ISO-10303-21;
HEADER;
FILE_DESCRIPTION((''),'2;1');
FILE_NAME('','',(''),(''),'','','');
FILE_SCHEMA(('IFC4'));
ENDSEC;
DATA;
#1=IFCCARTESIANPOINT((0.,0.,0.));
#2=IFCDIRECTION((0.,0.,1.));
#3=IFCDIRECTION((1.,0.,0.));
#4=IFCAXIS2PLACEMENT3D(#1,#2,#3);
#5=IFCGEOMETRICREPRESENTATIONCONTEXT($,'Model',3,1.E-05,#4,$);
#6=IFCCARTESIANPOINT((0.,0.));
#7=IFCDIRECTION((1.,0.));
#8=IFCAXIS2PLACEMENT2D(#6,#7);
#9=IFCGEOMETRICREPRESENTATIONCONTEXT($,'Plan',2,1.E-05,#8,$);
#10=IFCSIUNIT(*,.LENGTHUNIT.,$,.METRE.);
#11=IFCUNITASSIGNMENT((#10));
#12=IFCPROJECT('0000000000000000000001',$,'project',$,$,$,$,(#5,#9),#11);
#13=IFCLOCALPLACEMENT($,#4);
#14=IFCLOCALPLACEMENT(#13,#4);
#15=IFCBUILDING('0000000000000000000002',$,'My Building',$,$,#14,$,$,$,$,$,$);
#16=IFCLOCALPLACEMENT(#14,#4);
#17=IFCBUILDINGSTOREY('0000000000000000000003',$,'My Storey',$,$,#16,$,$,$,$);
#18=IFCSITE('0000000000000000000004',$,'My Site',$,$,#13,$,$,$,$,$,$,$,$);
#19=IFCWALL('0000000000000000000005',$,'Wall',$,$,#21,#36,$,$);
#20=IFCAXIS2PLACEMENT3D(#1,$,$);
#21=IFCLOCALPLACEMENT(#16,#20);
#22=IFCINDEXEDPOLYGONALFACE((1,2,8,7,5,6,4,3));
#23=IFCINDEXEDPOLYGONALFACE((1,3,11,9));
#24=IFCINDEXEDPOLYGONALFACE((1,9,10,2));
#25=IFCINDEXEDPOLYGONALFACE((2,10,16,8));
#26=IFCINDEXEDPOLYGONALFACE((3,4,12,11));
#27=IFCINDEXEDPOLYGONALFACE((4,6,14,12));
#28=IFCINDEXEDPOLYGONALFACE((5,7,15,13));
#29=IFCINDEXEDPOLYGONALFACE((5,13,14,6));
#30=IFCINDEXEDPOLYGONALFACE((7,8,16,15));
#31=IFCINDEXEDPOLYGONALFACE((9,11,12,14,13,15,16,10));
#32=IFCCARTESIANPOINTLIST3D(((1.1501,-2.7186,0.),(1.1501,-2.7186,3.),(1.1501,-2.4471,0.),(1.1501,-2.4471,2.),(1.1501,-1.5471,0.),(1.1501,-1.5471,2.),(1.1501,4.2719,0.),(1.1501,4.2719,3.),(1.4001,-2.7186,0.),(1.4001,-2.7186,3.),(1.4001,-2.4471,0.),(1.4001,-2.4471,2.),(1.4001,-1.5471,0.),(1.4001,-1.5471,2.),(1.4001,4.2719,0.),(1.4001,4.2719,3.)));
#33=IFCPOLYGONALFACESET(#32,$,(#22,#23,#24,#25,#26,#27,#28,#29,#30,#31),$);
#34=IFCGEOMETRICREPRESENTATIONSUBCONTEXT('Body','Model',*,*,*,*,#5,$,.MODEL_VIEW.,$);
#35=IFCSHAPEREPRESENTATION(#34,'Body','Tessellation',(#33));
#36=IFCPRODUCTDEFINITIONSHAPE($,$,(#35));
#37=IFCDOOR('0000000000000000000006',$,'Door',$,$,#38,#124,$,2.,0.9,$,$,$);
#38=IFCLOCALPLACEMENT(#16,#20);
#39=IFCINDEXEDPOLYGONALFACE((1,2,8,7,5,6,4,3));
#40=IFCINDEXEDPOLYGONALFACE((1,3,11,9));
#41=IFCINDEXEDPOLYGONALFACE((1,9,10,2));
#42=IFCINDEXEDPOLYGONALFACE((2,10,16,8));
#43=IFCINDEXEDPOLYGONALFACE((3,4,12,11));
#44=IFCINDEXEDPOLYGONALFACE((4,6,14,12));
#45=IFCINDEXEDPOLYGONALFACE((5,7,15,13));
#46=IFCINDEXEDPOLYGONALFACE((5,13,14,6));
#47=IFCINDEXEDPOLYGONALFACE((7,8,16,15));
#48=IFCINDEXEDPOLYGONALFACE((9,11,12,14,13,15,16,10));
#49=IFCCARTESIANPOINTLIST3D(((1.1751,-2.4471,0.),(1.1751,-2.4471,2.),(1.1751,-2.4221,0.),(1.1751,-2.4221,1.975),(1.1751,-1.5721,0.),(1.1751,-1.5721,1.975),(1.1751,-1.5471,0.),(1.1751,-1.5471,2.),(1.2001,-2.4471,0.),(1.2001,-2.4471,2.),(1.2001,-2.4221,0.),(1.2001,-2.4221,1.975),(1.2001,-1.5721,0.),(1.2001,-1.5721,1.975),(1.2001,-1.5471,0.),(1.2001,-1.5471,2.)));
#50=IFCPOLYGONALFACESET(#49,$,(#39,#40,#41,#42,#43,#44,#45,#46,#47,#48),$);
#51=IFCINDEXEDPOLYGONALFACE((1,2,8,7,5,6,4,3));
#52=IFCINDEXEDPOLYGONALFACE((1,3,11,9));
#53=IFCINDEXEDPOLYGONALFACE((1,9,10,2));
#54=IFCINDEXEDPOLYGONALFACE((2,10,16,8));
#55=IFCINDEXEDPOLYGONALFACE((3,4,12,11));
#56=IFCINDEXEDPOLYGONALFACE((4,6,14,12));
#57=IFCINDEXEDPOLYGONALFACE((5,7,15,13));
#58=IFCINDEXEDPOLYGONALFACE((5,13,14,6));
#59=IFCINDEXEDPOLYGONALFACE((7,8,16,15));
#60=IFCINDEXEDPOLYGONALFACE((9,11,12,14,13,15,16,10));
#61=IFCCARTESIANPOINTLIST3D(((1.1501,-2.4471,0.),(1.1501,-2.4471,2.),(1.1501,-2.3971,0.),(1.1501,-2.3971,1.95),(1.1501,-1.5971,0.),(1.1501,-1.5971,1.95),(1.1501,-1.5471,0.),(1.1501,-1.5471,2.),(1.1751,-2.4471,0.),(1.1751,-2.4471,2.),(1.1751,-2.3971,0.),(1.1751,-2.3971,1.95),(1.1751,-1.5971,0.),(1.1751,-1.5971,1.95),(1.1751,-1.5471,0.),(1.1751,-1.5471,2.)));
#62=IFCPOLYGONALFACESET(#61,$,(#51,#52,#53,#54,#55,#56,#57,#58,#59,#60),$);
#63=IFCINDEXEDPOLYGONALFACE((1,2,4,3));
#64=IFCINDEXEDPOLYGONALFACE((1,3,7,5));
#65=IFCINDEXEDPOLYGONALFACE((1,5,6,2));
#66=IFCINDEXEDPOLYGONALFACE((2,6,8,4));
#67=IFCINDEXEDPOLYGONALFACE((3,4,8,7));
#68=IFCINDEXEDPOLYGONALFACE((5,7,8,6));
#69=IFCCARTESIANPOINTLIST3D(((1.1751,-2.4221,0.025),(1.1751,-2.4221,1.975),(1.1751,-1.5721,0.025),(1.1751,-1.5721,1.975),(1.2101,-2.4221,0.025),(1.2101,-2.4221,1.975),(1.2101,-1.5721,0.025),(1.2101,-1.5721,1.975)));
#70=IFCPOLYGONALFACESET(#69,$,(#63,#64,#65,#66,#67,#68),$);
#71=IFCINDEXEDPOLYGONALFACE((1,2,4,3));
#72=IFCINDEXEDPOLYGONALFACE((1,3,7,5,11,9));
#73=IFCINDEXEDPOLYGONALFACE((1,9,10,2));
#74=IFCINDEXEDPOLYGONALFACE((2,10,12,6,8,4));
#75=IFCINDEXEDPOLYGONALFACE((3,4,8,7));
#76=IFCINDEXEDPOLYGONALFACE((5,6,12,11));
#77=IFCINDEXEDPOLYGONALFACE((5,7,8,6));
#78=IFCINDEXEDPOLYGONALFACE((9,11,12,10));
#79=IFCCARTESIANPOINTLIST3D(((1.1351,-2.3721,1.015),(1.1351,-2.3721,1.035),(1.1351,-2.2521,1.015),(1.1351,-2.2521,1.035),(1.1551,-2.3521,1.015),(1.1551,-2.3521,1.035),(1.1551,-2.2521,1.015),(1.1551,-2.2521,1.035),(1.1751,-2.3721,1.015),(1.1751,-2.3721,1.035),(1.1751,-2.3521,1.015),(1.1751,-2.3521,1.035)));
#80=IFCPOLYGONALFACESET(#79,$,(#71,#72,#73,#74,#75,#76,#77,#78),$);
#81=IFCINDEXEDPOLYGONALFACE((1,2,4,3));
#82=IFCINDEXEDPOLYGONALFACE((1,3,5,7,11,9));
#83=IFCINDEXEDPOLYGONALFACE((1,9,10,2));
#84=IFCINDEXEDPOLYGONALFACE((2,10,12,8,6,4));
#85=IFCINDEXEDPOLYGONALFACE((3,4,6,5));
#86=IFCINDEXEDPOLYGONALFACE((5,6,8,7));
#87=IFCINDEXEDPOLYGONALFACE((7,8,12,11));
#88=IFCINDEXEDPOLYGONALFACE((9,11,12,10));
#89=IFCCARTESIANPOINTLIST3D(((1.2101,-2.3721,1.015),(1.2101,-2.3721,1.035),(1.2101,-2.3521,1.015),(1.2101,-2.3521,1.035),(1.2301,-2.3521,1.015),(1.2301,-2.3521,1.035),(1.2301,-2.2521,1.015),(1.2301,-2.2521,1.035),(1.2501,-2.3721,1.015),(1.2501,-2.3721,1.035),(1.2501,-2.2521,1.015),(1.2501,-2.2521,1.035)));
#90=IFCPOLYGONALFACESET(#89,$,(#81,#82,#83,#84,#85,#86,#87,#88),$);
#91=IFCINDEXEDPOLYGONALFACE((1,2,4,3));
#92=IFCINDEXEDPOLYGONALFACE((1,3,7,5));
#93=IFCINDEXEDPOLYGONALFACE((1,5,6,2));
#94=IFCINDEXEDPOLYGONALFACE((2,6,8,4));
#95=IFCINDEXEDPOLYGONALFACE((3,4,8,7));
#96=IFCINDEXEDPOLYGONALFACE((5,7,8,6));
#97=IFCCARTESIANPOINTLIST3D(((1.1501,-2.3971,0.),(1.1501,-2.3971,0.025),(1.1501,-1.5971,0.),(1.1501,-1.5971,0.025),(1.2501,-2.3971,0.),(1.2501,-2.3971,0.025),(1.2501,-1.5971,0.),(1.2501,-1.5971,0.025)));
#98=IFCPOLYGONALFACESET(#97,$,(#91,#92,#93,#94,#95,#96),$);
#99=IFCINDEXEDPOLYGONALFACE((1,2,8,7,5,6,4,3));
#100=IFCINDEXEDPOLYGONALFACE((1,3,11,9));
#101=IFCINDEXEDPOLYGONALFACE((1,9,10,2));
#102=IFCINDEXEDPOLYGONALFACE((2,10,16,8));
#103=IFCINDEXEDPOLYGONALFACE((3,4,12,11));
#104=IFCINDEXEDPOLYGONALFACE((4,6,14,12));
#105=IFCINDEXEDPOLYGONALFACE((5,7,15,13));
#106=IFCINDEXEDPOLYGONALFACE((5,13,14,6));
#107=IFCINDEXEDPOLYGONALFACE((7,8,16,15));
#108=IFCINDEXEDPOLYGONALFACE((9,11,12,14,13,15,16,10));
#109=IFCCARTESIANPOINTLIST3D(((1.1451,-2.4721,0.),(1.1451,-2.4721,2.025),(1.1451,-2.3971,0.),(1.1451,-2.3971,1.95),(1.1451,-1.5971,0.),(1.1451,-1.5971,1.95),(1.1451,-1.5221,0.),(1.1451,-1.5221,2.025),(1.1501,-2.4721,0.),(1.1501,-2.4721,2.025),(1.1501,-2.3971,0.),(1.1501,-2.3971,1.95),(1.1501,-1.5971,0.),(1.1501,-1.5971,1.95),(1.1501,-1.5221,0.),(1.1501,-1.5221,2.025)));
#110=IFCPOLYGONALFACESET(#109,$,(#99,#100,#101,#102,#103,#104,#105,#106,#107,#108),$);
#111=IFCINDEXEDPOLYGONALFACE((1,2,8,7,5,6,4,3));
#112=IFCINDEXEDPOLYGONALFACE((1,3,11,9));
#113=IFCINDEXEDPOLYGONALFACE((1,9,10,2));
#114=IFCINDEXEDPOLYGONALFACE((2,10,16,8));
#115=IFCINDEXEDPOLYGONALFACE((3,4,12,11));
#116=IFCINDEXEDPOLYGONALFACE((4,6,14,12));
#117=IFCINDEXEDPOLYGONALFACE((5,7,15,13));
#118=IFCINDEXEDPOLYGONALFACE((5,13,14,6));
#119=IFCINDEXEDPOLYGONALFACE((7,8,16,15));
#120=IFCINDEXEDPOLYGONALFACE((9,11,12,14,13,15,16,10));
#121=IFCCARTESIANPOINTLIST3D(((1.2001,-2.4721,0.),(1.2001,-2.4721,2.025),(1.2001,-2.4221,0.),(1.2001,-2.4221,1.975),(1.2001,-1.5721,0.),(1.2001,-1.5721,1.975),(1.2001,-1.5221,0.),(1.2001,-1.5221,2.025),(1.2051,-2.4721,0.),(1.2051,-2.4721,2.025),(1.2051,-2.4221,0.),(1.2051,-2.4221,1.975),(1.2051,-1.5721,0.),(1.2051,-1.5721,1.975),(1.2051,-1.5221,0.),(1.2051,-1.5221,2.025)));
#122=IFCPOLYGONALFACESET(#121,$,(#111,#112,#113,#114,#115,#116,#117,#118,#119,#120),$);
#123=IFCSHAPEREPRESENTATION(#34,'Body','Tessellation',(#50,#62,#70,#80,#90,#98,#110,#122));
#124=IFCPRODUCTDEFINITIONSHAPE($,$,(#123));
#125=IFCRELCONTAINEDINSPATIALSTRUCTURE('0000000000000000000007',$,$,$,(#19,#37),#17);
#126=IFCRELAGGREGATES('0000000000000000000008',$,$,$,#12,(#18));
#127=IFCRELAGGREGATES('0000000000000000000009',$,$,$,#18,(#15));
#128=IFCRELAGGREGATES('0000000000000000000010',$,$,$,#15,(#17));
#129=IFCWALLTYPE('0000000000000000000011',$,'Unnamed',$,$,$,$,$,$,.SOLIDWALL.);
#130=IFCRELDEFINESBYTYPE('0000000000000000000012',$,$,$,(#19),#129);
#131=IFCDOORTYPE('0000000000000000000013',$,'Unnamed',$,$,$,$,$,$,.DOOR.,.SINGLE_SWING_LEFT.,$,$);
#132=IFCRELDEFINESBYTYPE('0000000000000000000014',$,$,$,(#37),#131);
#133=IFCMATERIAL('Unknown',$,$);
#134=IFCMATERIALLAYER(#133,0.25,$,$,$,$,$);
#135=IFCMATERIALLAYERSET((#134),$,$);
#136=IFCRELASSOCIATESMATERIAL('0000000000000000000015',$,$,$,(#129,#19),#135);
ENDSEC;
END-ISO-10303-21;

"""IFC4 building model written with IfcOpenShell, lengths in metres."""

from ifc_helpers import new_model, entity, si_unit, frame, origin_with_axes, origin_2d_with_axis, place, context, subcontext, project, spatial, line, indexed_curve, outline, extrude, shape, source, transform, mapped, material, layer, layer_set, layer_usage, type_object, type_shapes, element, fill, save


model = new_model("IFC4")

# Units and contexts
model_context = context("Model", 3, precision=1e-05, world=origin_with_axes())
plan_context = context("Plan", 2, precision=1e-05, world=origin_2d_with_axis())
body_context_1 = subcontext(model_context, "Body", "Model", "MODEL_VIEW")
body_context_2 = subcontext(plan_context, "Body", "Plan", "PLAN_VIEW")
ifc_project = project(units=[si_unit("LENGTHUNIT", "METRE")], contexts=[model_context, plan_context])

# Site, building, storey
site_placement = place(None, origin_with_axes())
site = spatial("IfcSite", under=ifc_project, at=site_placement, Name="My Site")
building_placement = place(site_placement, origin_with_axes())
building = spatial("IfcBuilding", under=site, at=building_placement, Name="My Building")
storey_placement = place(building_placement, origin_with_axes())
storey = spatial("IfcBuildingStorey", under=building, at=storey_placement, Name="My Storey")

# Shared definitions
ifc_material = material(Name="Unknown")

# Shared definitions
ifc_layer_1 = layer(ifc_material, 0.25)
ifc_layer_set_1 = layer_set([ifc_layer_1])
wall_type_1 = type_object("IfcWallType", Name="Unnamed", PredefinedType="SOLIDWALL", material=ifc_layer_set_1)

# Wall, opening, door
ifc_layer_usage_1 = layer_usage(ifc_layer_set_1, "AXIS2", "POSITIVE", 0.0)
wall_1_placement = place(storey_placement, frame((1.1501, 4.2719, 0.0), z_axis=(0.0, 0.0, 1.0), x_axis=(0.0, -1.0, 0.0)))
wall_1 = element("IfcWall", 1, at=wall_1_placement, inside=storey, type_object=wall_type_1, material=ifc_layer_usage_1, Name="Wall", context=body_context_1, shape_type="SweptSolid", body=[
    extrude(outline(indexed_curve([(0.0, 0.0), (0.0, 0.25), (6.9904, 0.25), (6.9904, 0.0)], segments=[line(1, 2, 3, 4, 1)])), origin_with_axes(), (0.0, 0.0, 1.0), 3.0),
])
shared_shape_1 = source(origin_with_axes(), body_context_1, "Body", "SweptSolid", [
    extrude(outline(indexed_curve([(0.0, 0.0), (0.9, 0.0), (0.9, 2.0), (0.0, 2.0)], segments=[line(1, 2, 3, 4, 1)])), frame((0.0, -0.6, 0.0), z_axis=(0.0, -1.0, 0.0), x_axis=(1.0, 0.0, 0.0)), (0.0, 0.0, -1.0), 1.2),
])
opening_1_placement = place(wall_1_placement, frame((5.819, 0.0, 0.0), z_axis=(0.0, 0.0, 1.0), x_axis=(1.0, 0.0, 0.0)))
opening_1 = element("IfcOpeningElement", 2, at=opening_1_placement, cuts=wall_1, PredefinedType="OPENING", context=body_context_1, shape_type="MappedRepresentation", body=[
    mapped(shared_shape_1, transform((0.0, 0.0, 0.0), x_axis=(1.0, 0.0, 0.0), y_axis=(0.0, 1.0, 0.0), z_axis=(0.0, 0.0, 1.0), scale=1.0)),
])
door_type = type_object("IfcDoorType", Name="Unnamed", OperationType="SINGLE_SWING_LEFT", PredefinedType="DOOR")
shared_shape_2 = source(origin_with_axes(), body_context_1, "Body", "SweptSolid", [
    extrude(outline(indexed_curve([(0.0, 0.0), (0.0, 2.0), (0.9, 2.0), (0.9, 0.0), (0.875, 0.0), (0.875, 1.975), (0.025, 1.975), (0.025, 0.0)], segments=[line(1, 2, 3, 4, 5, 6, 7, 8, 1)])), frame((0.0, 0.025, 0.0), z_axis=(0.0, -1.0, 0.0), x_axis=(1.0, 0.0, 0.0)), (0.0, 0.0, -1.0), 0.025),
    extrude(outline(indexed_curve([(0.0, 0.0), (0.0, 2.0), (0.9, 2.0), (0.9, 0.0), (0.85, 0.0), (0.85, 1.95), (0.05, 1.95), (0.05, 0.0)], segments=[line(1, 2, 3, 4, 5, 6, 7, 8, 1)])), frame((0.0, 0.0, 0.0), z_axis=(0.0, -1.0, 0.0), x_axis=(1.0, 0.0, 0.0)), (0.0, 0.0, -1.0), 0.025),
    extrude(outline(indexed_curve([(0.0, 0.0), (0.85, 0.0), (0.85, 0.035), (0.0, 0.035)], segments=[line(1, 2, 3, 4, 1)])), frame((0.025, 0.025, 0.025), z_axis=(0.0, 0.0, 1.0), x_axis=(1.0, 0.0, 0.0)), (0.0, 0.0, 1.0), 1.95),
    extrude(outline(indexed_curve([(0.0, 0.0), (0.0, -0.04), (-0.12, -0.04), (-0.12, -0.02), (-0.02, -0.02), (-0.02, 0.0)], segments=[line(1, 2, 3, 4, 5, 6, 1)])), frame((0.825, 0.025, 1.015), z_axis=(0.0, 0.0, 1.0), x_axis=(1.0, 0.0, 0.0)), (0.0, 0.0, 1.0), 0.02),
    extrude(outline(indexed_curve([(0.0, 0.0), (0.0, 0.04), (-0.12, 0.04), (-0.12, 0.02), (-0.02, 0.02), (-0.02, 0.0)], segments=[line(1, 2, 3, 4, 5, 6, 1)])), frame((0.825, 0.06, 1.015), z_axis=(0.0, 0.0, 1.0), x_axis=(1.0, 0.0, 0.0)), (0.0, 0.0, 1.0), 0.02),
    extrude(outline(indexed_curve([(0.0, 0.0), (0.8, 0.0), (0.8, 0.1), (0.0, 0.1)], segments=[line(1, 2, 3, 4, 1)])), frame((0.05, 0.0, 0.0), z_axis=(0.0, 0.0, 1.0), x_axis=(1.0, 0.0, 0.0)), (0.0, 0.0, 1.0), 0.025),
    extrude(outline(indexed_curve([(0.0, 0.0), (0.0, 2.025), (0.95, 2.025), (0.95, 0.0), (0.875, 0.0), (0.875, 1.95), (0.075, 1.95), (0.075, 0.0)], segments=[line(1, 2, 3, 4, 5, 6, 7, 8, 1)])), frame((-0.025, -0.005, 0.0), z_axis=(0.0, -1.0, 0.0), x_axis=(1.0, 0.0, 0.0)), (0.0, 0.0, -1.0), 0.005),
    extrude(outline(indexed_curve([(0.0, 0.0), (0.0, 2.025), (0.95, 2.025), (0.95, 0.0), (0.9, 0.0), (0.9, 1.975), (0.05, 1.975), (0.05, 0.0)], segments=[line(1, 2, 3, 4, 5, 6, 7, 8, 1)])), frame((-0.025, 0.05, 0.0), z_axis=(0.0, -1.0, 0.0), x_axis=(1.0, 0.0, 0.0)), (0.0, 0.0, -1.0), 0.005),
])
shared_shape_3 = source(origin_with_axes(), body_context_2, "Body", "Curve2D", [
    entity("IfcIndexedPolyCurve", entity("IfcCartesianPointList2D", [[0.0, 0.0], [0.0, 0.05], [0.025, 0.05], [0.025, 0.025], [0.05, 0.025], [0.05, 0.0]]), [entity("IfcLineIndex", [1, 2, 3, 4, 5, 6, 1])]),
    entity("IfcIndexedPolyCurve", entity("IfcCartesianPointList2D", [[0.9, 0.0], [0.9, 0.05], [0.875, 0.05], [0.875, 0.025], [0.85, 0.025], [0.85, 0.0]]), [entity("IfcLineIndex", [1, 2, 3, 4, 5, 6, 1])]),
    entity("IfcTrimmedCurve", entity("IfcEllipse", entity("IfcAxis2Placement2D", entity("IfcCartesianPoint", [0.06, 0.05]), entity("IfcDirection", [1.0, 0.0])), 0.815, 0.85), [entity("IfcCartesianPoint", [0.875, 0.05])], [entity("IfcCartesianPoint", [0.06, 0.9])], True, "CARTESIAN"),
    entity("IfcIndexedPolyCurve", entity("IfcCartesianPointList2D", [[0.025, 0.05], [0.06, 0.05], [0.06, 0.9], [0.025, 0.9]]), [entity("IfcLineIndex", [1, 2, 3, 4, 1])]),
])
type_shapes(door_type, [shared_shape_2, shared_shape_3])
door_1_placement = place(opening_1_placement, origin_with_axes())
door_1 = element("IfcDoor", 3, at=door_1_placement, inside=storey, type_object=door_type, Name="Door", OverallHeight=2.0, OverallWidth=0.9, shapes=[
    shape(body_context_1, "Body", "MappedRepresentation", [mapped(shared_shape_2, transform((0.0, 0.0, 0.0), x_axis=(1.0, 0.0, 0.0), y_axis=(0.0, 1.0, 0.0), z_axis=(0.0, 0.0, 1.0), scale=1.0))]),
    shape(body_context_2, "Body", "MappedRepresentation", [mapped(shared_shape_3, transform((0.0, 0.0, 0.0), x_axis=(1.0, 0.0, 0.0), y_axis=(0.0, 1.0, 0.0), z_axis=(0.0, 0.0, 1.0), scale=1.0))]),
])
fill(opening_1, door_1)

save(model, "model.ifc")
